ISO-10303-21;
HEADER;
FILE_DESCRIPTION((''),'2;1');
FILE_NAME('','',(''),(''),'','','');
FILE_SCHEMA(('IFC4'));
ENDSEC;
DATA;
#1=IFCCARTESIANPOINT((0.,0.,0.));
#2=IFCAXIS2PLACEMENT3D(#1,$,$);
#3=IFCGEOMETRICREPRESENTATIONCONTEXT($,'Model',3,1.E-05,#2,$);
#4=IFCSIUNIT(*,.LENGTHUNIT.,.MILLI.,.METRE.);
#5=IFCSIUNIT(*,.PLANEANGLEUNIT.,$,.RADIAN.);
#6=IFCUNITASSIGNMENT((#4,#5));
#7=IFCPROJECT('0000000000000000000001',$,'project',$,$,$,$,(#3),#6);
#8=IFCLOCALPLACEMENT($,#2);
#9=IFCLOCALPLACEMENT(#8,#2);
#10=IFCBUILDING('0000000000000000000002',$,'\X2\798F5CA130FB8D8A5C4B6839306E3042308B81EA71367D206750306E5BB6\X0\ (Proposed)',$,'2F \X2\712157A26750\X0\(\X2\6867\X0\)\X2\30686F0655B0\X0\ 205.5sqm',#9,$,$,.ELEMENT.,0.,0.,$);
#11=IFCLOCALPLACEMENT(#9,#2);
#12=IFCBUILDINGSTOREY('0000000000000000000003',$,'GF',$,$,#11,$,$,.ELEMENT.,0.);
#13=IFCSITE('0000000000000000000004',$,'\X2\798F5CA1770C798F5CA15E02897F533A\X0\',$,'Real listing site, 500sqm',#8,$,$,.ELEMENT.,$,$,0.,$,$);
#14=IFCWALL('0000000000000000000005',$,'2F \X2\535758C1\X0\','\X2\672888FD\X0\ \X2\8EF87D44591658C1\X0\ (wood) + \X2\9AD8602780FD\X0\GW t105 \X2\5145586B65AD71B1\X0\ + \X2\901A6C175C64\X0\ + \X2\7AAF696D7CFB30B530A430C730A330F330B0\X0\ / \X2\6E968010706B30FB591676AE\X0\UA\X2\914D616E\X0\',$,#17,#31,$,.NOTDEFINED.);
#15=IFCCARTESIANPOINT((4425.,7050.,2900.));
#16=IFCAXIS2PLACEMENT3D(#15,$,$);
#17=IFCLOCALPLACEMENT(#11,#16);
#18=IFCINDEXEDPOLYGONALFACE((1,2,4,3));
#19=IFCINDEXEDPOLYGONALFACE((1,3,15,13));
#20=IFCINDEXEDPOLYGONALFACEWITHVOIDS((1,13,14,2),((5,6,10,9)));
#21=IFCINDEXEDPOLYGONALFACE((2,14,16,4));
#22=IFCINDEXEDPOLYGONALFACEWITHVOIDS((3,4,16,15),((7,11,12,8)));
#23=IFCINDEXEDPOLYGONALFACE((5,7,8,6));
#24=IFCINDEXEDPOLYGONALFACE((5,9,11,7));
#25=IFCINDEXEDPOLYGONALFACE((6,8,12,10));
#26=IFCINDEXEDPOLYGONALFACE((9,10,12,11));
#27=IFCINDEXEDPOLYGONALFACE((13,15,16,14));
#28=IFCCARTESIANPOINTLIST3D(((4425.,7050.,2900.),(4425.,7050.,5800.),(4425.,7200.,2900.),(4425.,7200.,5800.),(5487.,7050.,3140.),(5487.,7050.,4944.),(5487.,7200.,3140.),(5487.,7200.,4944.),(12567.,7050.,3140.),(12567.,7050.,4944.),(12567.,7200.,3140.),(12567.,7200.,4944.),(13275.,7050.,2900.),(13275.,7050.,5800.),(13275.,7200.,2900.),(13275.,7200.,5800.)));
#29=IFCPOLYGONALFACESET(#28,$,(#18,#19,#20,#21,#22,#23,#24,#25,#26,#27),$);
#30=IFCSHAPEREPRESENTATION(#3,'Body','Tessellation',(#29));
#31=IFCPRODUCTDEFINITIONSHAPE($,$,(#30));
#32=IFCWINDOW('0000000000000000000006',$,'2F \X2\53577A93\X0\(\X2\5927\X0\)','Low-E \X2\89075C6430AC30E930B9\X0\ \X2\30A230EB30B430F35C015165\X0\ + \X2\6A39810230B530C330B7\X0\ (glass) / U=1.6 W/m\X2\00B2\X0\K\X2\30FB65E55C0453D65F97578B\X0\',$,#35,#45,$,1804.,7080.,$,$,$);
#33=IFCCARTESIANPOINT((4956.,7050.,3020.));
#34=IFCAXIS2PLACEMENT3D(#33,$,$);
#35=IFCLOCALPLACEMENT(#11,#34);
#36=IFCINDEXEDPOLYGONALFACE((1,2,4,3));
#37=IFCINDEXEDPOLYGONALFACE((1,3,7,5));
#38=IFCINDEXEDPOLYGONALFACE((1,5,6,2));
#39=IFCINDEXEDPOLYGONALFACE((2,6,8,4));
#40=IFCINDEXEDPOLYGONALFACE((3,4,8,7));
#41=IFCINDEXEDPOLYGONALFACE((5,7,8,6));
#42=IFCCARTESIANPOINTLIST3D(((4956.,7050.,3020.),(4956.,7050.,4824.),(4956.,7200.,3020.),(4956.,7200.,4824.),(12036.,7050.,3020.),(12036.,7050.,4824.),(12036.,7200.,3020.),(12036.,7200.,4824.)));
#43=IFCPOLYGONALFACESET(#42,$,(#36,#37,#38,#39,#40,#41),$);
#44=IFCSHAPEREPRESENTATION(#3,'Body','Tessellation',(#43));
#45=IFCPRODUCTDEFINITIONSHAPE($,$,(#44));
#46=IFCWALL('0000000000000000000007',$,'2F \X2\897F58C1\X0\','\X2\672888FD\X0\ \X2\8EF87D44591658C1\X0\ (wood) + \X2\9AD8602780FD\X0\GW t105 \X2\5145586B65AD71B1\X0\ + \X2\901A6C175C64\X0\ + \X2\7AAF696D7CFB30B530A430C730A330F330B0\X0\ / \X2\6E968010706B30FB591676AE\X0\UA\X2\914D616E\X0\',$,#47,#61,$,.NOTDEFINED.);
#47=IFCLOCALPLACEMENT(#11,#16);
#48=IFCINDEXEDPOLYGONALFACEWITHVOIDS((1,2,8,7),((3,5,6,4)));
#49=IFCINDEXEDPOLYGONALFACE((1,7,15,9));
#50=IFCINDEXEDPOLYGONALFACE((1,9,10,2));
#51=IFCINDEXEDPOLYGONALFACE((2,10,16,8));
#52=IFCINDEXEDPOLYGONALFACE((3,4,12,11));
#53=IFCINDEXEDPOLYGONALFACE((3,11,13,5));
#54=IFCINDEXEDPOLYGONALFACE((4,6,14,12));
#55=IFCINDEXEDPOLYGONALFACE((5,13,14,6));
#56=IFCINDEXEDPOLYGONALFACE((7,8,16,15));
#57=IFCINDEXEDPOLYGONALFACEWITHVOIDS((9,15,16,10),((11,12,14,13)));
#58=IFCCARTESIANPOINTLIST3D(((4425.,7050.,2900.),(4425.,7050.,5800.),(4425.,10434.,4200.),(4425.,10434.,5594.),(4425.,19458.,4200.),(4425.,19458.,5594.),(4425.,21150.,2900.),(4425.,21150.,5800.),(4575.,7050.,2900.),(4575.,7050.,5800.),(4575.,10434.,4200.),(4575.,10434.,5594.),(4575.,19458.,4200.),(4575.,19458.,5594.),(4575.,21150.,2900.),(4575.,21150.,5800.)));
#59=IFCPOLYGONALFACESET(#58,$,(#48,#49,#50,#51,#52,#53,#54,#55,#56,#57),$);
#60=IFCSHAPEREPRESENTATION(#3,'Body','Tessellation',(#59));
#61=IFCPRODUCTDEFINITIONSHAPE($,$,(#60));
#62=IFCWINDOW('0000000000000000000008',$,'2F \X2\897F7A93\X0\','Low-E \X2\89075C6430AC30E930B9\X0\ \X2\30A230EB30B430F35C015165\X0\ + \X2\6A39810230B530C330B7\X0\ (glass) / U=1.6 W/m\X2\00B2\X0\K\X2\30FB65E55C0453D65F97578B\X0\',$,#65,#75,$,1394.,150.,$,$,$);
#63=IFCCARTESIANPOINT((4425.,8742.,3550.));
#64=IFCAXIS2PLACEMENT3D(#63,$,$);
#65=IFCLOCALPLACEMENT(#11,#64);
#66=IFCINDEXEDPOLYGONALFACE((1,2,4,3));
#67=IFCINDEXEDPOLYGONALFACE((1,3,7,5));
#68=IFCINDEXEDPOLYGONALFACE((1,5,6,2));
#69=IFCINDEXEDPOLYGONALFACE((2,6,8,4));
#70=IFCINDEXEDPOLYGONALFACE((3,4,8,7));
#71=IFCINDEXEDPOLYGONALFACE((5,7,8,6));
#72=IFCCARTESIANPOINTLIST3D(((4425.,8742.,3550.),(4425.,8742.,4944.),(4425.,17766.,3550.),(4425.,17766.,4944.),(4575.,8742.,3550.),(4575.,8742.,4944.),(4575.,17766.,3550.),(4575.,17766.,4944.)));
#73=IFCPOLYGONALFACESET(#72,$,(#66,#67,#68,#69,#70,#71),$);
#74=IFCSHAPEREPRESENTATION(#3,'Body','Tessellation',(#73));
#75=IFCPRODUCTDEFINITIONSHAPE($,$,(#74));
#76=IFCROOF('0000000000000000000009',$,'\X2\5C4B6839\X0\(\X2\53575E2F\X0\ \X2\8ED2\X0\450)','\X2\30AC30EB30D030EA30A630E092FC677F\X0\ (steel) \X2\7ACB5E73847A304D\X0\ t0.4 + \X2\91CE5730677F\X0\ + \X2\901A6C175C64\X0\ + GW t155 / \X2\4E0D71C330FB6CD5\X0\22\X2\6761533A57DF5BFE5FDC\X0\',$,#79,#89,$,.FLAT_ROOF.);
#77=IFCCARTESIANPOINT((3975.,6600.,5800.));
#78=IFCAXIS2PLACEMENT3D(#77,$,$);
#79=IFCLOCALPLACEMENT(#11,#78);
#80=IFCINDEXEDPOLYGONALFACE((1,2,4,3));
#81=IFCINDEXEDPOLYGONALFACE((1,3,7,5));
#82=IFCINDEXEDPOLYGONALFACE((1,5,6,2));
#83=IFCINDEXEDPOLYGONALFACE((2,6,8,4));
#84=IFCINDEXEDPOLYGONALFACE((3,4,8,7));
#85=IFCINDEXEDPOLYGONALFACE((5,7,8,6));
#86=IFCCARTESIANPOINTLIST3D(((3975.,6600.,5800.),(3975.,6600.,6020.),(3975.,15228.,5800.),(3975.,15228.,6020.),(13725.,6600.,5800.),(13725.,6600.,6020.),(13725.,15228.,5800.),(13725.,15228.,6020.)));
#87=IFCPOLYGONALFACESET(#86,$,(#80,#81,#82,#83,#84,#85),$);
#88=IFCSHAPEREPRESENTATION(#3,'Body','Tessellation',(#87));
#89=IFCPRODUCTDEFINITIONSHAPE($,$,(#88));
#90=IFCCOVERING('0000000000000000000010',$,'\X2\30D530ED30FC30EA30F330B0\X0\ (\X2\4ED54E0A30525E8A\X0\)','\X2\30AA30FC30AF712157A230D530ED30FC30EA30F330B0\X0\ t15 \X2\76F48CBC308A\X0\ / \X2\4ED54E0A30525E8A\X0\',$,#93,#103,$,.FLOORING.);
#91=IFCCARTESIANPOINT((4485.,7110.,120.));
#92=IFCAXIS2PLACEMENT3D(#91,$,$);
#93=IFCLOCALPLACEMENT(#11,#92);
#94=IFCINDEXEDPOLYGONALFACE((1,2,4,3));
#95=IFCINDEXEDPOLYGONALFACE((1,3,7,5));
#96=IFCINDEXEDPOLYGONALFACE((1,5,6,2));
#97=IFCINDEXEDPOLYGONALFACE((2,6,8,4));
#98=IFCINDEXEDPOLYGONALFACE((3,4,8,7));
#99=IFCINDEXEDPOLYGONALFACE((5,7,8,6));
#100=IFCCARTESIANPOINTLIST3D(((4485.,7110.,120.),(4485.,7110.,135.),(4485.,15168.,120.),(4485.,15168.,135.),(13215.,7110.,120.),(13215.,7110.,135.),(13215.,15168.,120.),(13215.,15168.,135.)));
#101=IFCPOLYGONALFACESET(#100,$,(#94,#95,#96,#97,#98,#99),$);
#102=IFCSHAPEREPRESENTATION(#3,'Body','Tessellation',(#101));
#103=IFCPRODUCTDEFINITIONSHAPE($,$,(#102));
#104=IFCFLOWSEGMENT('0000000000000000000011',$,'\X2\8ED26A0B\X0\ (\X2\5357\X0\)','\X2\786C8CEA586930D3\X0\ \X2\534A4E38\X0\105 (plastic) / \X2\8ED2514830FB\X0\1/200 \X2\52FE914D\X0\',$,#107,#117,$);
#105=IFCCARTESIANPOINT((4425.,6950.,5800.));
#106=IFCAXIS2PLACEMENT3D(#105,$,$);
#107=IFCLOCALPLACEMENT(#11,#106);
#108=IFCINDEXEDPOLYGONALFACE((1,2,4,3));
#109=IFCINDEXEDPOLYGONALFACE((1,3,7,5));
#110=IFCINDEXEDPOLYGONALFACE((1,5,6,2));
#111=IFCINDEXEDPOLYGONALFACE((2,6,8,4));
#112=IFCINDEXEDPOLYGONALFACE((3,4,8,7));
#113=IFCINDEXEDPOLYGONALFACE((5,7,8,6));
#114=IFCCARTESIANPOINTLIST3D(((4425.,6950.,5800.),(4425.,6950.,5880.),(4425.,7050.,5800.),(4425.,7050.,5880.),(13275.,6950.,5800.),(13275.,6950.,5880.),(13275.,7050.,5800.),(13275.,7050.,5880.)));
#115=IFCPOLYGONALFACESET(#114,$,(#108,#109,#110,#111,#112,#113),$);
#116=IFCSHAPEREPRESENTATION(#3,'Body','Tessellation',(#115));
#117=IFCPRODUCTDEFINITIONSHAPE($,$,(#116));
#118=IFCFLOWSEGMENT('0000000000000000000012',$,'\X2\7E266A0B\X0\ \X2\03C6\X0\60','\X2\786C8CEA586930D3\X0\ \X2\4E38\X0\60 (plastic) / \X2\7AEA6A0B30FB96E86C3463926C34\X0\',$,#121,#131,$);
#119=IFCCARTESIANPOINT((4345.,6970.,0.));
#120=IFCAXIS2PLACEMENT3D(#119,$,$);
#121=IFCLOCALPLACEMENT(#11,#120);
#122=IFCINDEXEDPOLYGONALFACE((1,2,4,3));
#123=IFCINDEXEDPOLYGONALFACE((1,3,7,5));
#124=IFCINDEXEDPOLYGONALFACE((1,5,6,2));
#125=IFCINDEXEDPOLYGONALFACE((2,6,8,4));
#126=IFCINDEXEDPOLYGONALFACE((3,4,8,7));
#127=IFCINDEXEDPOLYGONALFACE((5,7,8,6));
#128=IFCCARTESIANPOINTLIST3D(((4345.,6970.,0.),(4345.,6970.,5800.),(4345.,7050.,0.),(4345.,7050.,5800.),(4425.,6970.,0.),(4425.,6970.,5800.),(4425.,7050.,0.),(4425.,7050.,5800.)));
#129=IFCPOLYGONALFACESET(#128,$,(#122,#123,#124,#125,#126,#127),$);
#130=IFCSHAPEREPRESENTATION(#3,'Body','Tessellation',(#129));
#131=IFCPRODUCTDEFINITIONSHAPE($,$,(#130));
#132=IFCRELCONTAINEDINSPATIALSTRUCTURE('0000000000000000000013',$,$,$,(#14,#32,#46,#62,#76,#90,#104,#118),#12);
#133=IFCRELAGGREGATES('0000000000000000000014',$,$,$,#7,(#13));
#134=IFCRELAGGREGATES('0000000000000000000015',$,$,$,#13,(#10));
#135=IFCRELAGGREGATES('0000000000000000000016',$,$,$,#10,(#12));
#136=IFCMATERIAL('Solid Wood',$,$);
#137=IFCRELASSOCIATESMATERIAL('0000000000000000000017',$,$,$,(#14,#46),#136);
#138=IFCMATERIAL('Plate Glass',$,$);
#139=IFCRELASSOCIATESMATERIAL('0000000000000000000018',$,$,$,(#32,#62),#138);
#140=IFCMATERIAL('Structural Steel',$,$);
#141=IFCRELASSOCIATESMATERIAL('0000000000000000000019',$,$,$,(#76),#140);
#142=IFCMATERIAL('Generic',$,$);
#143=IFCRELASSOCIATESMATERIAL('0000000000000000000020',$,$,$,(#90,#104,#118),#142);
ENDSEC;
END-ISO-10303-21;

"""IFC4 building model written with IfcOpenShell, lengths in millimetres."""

from ifc_helpers import new_model, si_unit, frame, frame_2d, origin, place, context, project, spatial, rectangle, extrude, material, element, fill, save


model = new_model("IFC4")

# Units and contexts
model_context = context("Model", 3, precision=1e-05, world=origin())
ifc_project = project(units=[si_unit("LENGTHUNIT", "METRE", prefix="MILLI"), si_unit("PLANEANGLEUNIT", "RADIAN")], contexts=[model_context])

# Site, building, storey
site_placement = place(None, origin())
site = spatial("IfcSite", under=ifc_project, at=site_placement, Name="福岡県福岡市西区", ObjectType="Real listing site, 500sqm", CompositionType="ELEMENT", RefElevation=0.0)
building_placement = place(site_placement, origin())
building = spatial("IfcBuilding", under=site, at=building_placement, Name="福岡・越屋根のある自然素材の家 (Proposed)", ObjectType="2F 無垢材(桧)と漆喰 205.5sqm", CompositionType="ELEMENT", ElevationOfRefHeight=0.0, ElevationOfTerrain=0.0)
storey_placement = place(building_placement, origin())
storey = spatial("IfcBuildingStorey", under=building, at=storey_placement, Name="GF", CompositionType="ELEMENT", Elevation=0.0)

# Shared definitions
ifc_material_1 = material(Name="Solid Wood")

# Shared definitions
ifc_material_2 = material(Name="Plate Glass")

# Walls, openings, windows
wall_1_placement = place(storey_placement, frame((4425.0, 7050.0, 2900.0)))
wall_1 = element("IfcWall", 1, at=wall_1_placement, inside=storey, material=ifc_material_1, Name="2F 南壁", Description="木製 軸組外壁 (wood) + 高性能GW t105 充填断熱 + 通気層 + 窯業系サイディング / 準耐火・外皮UA配慮", PredefinedType="NOTDEFINED", context=model_context, shape_type="SweptSolid", body=[
    extrude(rectangle(XDim=8850.0, YDim=150.0, at=frame_2d((4425.0, 75.0))), frame((4425.0, 7050.0, 2900.0)), (0.0, 0.0, 1.0), 2900.0),
])
opening_1_placement = place(storey_placement, frame((4956.0, 7050.0, 3020.0)))
opening_1 = element("IfcOpeningElement", 2, at=opening_1_placement, cuts=wall_1, PredefinedType="NOTDEFINED", context=model_context, shape_type="SweptSolid", body=[
    extrude(rectangle(XDim=7080.0, YDim=150.0, at=frame_2d((3540.0, 75.0))), frame((4956.0, 7050.0, 3020.0)), (0.0, 0.0, 1.0), 1804.0),
])
window_1_placement = place(storey_placement, frame((4956.0, 7050.0, 3020.0)))
window_1 = element("IfcWindow", 3, at=window_1_placement, inside=storey, material=ifc_material_2, Name="2F 南窓(大)", Description="Low-E 複層ガラス アルゴン封入 + 樹脂サッシ (glass) / U=1.6 W/m²K・日射取得型", OverallHeight=1804.0, OverallWidth=7080.0, context=model_context, shape_type="SweptSolid", body=[
    extrude(rectangle(XDim=7080.0, YDim=150.0, at=frame_2d((3540.0, 75.0))), frame((4956.0, 7050.0, 3020.0)), (0.0, 0.0, 1.0), 1804.0),
])
fill(opening_1, window_1)
wall_2_placement = place(storey_placement, frame((4425.0, 7050.0, 2900.0)))
wall_2 = element("IfcWall", 4, at=wall_2_placement, inside=storey, material=ifc_material_1, Name="2F 西壁", Description="木製 軸組外壁 (wood) + 高性能GW t105 充填断熱 + 通気層 + 窯業系サイディング / 準耐火・外皮UA配慮", PredefinedType="NOTDEFINED", context=model_context, shape_type="SweptSolid", body=[
    extrude(rectangle(XDim=150.0, YDim=14100.0, at=frame_2d((75.0, 7050.0))), frame((4425.0, 7050.0, 2900.0)), (0.0, 0.0, 1.0), 2900.0),
])
opening_2_placement = place(storey_placement, frame((4425.0, 8742.0, 3550.0)))
opening_2 = element("IfcOpeningElement", 5, at=opening_2_placement, cuts=wall_2, PredefinedType="NOTDEFINED", context=model_context, shape_type="SweptSolid", body=[
    extrude(rectangle(XDim=150.0, YDim=9024.0, at=frame_2d((75.0, 4512.0))), frame((4425.0, 8742.0, 3550.0)), (0.0, 0.0, 1.0), 1394.0),
])
window_2_placement = place(storey_placement, frame((4425.0, 8742.0, 3550.0)))
window_2 = element("IfcWindow", 6, at=window_2_placement, inside=storey, material=ifc_material_2, Name="2F 西窓", Description="Low-E 複層ガラス アルゴン封入 + 樹脂サッシ (glass) / U=1.6 W/m²K・日射取得型", OverallHeight=1394.0, OverallWidth=150.0, context=model_context, shape_type="SweptSolid", body=[
    extrude(rectangle(XDim=150.0, YDim=9024.0, at=frame_2d((75.0, 4512.0))), frame((4425.0, 8742.0, 3550.0)), (0.0, 0.0, 1.0), 1394.0),
])
fill(opening_2, window_2)

# Roof
ifc_material_3 = material(Name="Structural Steel")
for number, where, name in (
    (7, (3975.0, 6600.0, 5800.0), "屋根(南帯 軒450)"),
):
    element("IfcRoof", number, at=place(storey_placement, frame(where)), inside=storey, material=ifc_material_3, Name=name, Description="ガルバリウム鋼板 (steel) 立平葺き t0.4 + 野地板 + 通気層 + GW t155 / 不燃・法22条区域対応", PredefinedType="FLAT_ROOF", context=model_context, shape_type="SweptSolid", body=[
        extrude(rectangle(XDim=9750.0, YDim=8628.0, at=frame_2d((4875.0, 4314.0))), frame((3975.0, 6600.0, 5800.0)), (0.0, 0.0, 1.0), 220.0),
    ])

# Covering
ifc_material_4 = material(Name="Generic")
covering_placement = place(storey_placement, frame((4485.0, 7110.0, 120.0)))
element("IfcCovering", 8, at=covering_placement, inside=storey, material=ifc_material_4, Name="フローリング (仕上げ床)", Description="オーク無垢フローリング t15 直貼り / 仕上げ床", PredefinedType="FLOORING", context=model_context, shape_type="SweptSolid", body=[
    extrude(rectangle(XDim=8730.0, YDim=8058.0, at=frame_2d((4365.0, 4029.0))), frame((4485.0, 7110.0, 120.0)), (0.0, 0.0, 1.0), 15.0),
])

# Flow segments
flow_segment_1_placement = place(storey_placement, frame((4425.0, 6950.0, 5800.0)))
element("IfcFlowSegment", 9, at=flow_segment_1_placement, inside=storey, material=ifc_material_4, Name="軒樋 (南)", Description="硬質塩ビ 半丸105 (plastic) / 軒先・1/200 勾配", context=model_context, shape_type="SweptSolid", body=[
    extrude(rectangle(XDim=8850.0, YDim=100.0, at=frame_2d((4425.0, 50.0))), frame((4425.0, 6950.0, 5800.0)), (0.0, 0.0, 1.0), 80.0),
])
flow_segment_2_placement = place(storey_placement, frame((4345.0, 6970.0, 0.0)))
element("IfcFlowSegment", 10, at=flow_segment_2_placement, inside=storey, material=ifc_material_4, Name="縦樋 φ60", Description="硬質塩ビ 丸60 (plastic) / 竪樋・雨水排水", context=model_context, shape_type="SweptSolid", body=[
    extrude(rectangle(XDim=80.0, YDim=80.0, at=frame_2d((40.0, 40.0))), frame((4345.0, 6970.0, 0.0)), (0.0, 0.0, 1.0), 5800.0),
])

save(model, "model.ifc")
